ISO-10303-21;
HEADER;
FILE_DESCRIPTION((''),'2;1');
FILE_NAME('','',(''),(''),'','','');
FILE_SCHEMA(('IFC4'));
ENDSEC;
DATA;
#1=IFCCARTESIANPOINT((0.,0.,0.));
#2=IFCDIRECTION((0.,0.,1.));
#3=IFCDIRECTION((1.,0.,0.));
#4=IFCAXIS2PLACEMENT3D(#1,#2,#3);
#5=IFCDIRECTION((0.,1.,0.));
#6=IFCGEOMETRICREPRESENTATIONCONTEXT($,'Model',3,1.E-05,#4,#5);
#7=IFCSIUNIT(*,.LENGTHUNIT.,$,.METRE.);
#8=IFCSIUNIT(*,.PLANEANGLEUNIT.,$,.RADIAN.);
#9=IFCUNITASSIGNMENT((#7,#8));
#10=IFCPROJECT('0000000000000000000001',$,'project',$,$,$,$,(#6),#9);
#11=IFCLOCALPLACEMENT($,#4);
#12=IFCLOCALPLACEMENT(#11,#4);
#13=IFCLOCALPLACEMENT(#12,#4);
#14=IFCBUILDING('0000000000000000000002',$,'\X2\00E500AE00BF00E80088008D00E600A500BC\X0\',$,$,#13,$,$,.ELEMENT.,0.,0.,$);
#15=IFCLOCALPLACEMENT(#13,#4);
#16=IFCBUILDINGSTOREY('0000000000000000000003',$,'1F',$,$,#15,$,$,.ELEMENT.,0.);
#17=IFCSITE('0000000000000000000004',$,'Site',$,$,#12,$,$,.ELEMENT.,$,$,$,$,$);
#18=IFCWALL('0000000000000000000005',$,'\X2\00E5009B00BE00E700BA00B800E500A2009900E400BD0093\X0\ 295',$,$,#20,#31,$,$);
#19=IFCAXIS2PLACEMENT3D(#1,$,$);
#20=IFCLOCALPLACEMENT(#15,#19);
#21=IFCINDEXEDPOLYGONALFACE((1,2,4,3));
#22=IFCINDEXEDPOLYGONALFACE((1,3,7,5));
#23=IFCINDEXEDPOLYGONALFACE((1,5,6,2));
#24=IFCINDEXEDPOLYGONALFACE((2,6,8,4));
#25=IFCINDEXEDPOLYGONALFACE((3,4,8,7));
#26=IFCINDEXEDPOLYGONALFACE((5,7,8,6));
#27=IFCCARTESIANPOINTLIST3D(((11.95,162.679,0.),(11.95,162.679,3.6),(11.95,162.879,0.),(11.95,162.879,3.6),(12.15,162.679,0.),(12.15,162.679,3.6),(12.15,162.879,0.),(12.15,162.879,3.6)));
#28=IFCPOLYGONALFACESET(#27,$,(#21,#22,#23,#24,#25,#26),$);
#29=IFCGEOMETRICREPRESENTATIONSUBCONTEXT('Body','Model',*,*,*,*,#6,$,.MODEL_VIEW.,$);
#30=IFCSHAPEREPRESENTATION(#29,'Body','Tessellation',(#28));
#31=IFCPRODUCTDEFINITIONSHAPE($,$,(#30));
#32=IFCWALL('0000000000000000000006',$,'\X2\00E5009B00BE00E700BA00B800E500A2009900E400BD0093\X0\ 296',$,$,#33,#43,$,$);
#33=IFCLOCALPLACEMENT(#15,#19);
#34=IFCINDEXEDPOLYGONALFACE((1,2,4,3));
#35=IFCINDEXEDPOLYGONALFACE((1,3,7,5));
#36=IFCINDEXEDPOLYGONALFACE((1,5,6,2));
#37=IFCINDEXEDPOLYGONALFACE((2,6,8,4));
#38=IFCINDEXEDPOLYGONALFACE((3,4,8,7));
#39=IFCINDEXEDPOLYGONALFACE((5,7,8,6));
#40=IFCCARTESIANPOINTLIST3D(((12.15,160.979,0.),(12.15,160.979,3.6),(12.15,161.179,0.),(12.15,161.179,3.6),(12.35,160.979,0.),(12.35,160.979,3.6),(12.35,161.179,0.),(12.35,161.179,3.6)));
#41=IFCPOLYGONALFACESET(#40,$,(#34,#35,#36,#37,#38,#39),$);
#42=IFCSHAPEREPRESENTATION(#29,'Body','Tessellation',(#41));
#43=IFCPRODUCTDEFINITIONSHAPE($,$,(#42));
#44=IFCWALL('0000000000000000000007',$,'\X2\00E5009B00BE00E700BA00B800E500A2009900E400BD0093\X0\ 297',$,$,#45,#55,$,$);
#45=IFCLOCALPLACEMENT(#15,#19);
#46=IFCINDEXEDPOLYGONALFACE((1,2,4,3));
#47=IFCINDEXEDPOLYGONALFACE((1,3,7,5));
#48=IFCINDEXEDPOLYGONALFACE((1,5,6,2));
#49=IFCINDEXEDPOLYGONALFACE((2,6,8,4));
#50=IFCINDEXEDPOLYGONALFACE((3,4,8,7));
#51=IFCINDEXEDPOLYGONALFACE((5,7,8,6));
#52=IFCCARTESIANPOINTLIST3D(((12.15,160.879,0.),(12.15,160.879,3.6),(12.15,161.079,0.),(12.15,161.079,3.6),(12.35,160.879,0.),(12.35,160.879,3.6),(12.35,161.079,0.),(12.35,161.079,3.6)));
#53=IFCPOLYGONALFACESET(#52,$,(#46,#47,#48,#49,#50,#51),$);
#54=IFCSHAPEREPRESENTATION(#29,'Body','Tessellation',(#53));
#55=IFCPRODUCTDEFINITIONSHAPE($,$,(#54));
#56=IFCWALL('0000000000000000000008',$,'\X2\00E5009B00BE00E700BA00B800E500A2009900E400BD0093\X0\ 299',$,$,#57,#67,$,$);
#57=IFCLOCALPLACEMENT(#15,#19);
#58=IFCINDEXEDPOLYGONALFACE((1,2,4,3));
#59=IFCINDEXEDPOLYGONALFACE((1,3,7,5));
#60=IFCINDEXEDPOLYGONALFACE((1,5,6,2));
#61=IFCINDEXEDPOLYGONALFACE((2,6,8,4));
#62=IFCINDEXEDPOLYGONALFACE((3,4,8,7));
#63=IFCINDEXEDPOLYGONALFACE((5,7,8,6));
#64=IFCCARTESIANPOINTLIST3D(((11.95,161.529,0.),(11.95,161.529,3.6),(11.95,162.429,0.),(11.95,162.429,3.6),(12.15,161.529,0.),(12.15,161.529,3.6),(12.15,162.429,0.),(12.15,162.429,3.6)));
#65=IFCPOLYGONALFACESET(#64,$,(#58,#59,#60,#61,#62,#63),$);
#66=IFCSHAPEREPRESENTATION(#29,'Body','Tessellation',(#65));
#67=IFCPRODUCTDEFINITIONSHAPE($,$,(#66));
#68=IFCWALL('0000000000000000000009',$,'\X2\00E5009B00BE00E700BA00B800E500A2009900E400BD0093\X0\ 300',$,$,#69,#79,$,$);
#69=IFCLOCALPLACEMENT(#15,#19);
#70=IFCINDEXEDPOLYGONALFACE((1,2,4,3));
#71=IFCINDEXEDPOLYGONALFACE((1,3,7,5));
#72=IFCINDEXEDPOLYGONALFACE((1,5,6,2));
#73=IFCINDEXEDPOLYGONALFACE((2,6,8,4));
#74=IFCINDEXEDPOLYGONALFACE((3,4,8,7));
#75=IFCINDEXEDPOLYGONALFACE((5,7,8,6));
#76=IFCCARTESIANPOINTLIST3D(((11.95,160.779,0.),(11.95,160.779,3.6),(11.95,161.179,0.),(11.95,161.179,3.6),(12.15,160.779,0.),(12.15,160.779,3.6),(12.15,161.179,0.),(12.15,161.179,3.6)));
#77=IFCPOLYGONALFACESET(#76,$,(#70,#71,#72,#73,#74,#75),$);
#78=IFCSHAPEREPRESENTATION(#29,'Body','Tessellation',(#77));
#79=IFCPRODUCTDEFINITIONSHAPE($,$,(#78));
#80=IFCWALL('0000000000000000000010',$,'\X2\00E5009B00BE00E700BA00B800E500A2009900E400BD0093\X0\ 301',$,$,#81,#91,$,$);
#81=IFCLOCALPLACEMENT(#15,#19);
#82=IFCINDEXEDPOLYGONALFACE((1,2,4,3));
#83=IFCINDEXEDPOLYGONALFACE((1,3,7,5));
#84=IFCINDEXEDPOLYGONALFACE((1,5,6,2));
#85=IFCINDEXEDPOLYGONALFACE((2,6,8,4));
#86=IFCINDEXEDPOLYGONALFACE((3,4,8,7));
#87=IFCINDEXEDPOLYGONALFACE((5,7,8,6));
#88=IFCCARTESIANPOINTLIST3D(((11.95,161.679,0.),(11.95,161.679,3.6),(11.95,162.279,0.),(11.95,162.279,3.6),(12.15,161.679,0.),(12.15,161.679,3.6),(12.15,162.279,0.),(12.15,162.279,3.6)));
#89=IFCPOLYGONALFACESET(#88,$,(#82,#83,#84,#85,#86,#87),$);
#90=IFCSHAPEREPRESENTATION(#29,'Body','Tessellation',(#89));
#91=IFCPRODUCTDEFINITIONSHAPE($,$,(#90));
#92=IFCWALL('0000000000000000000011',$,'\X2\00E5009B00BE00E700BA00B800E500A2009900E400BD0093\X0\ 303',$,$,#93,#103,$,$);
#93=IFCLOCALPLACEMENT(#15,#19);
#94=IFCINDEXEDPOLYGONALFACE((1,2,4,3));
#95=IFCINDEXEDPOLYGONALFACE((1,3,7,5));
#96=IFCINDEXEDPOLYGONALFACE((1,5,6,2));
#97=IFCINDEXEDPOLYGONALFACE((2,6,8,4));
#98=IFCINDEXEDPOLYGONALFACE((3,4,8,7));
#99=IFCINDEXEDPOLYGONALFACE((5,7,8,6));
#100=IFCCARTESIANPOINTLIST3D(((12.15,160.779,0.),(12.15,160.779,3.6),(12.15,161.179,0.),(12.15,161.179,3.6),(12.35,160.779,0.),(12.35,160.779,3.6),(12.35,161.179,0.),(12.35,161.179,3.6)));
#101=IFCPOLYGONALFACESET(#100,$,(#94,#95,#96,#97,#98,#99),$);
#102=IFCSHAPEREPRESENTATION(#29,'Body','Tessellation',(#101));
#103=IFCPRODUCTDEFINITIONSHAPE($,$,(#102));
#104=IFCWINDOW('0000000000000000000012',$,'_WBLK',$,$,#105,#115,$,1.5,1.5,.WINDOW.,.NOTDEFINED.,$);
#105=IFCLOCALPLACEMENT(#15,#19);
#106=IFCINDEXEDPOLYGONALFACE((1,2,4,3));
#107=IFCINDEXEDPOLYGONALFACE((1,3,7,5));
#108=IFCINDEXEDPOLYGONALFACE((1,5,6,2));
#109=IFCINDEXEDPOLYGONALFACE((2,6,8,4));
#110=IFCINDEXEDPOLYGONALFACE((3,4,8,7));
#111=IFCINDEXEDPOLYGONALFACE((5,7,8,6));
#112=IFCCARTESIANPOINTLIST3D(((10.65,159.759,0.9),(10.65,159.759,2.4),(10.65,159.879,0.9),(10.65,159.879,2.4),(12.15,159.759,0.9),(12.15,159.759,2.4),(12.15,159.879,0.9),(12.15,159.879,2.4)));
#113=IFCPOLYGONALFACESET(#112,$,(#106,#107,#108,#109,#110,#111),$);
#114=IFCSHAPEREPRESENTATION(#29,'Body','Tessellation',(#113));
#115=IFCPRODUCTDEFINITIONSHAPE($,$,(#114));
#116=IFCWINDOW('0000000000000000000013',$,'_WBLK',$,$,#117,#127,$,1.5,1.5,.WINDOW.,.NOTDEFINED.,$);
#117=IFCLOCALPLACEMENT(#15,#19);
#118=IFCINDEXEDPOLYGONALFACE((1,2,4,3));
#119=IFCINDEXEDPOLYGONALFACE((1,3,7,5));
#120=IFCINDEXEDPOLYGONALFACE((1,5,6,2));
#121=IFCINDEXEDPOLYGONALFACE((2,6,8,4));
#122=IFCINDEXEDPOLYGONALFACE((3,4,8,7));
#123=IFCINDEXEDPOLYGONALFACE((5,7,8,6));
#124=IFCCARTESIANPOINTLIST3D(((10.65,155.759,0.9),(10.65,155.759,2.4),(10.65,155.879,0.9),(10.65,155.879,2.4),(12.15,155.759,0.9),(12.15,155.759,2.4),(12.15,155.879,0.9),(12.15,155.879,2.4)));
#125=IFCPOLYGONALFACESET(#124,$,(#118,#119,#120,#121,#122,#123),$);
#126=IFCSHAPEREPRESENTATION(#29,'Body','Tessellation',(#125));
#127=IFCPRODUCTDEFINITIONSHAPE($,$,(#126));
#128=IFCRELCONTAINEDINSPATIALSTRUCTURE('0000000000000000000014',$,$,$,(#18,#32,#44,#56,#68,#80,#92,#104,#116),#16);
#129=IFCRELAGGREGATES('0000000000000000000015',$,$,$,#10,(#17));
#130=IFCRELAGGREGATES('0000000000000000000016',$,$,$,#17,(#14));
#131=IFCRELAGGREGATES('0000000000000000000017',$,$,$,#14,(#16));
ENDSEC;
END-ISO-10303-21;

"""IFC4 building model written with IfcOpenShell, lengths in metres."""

from ifc_helpers import new_model, si_unit, direction, frame, frame_2d, origin_with_axes, place, context, subcontext, project, spatial, rectangle, extrude, element, save


model = new_model("IFC4")

# Units and contexts
model_context = context("Model", 3, precision=1e-05, world=origin_with_axes(), true_north=direction((0.0, 1.0, 0.0)))
body_context = subcontext(model_context, "Body", "Model", "MODEL_VIEW")
ifc_project = project(units=[si_unit("LENGTHUNIT", "METRE"), si_unit("PLANEANGLEUNIT", "RADIAN")], contexts=[model_context])

# Site, building, storey
placement = place(None, origin_with_axes())
site_placement = place(placement, origin_with_axes())
site = spatial("IfcSite", under=ifc_project, at=site_placement, Name="Site", CompositionType="ELEMENT")
building_placement = place(site_placement, origin_with_axes())
building = spatial("IfcBuilding", under=site, at=building_placement, Name="å®¿è\u0088\u008dæ¥¼", CompositionType="ELEMENT", ElevationOfRefHeight=0.0, ElevationOfTerrain=0.0)
storey_placement = place(building_placement, origin_with_axes())
storey = spatial("IfcBuildingStorey", under=building, at=storey_placement, Name="1F", CompositionType="ELEMENT", Elevation=0.0)

# Walls
for number, where, z_axis, x_axis, name in (
    (1, (12.05, 162.779, 0.0), (0.0, 0.0, 1.0), (1.0, 0.0, 0.0), "å\u009b¾çº¸å¢\u0099ä½\u0093 295"),
    (2, (12.25, 161.079, 0.0), (0.0, 0.0, 1.0), (-1.0, 0.0, 0.0), "å\u009b¾çº¸å¢\u0099ä½\u0093 296"),
    (3, (12.25, 160.979, 0.0), (0.0, 0.0, 1.0), (-1.0, 0.0, 0.0), "å\u009b¾çº¸å¢\u0099ä½\u0093 297"),
):
    element("IfcWall", number, at=place(storey_placement, frame(where, z_axis=z_axis, x_axis=x_axis)), inside=storey, Name=name, context=body_context, shape_type="SweptSolid", body=[
        extrude(rectangle(XDim=0.2, YDim=0.2, at=frame_2d((0.0, 0.0), x_axis=(1.0, 0.0, 0.0))), frame((0.0, 0.0, 0.0), z_axis=(0.0, 0.0, 1.0)), (0.0, 0.0, 1.0), 3.6),
    ])
wall_1_placement = place(storey_placement, frame((12.05, 161.979, 0.0), z_axis=(0.0, 0.0, 1.0), x_axis=(0.0, 1.0, 0.0)))
element("IfcWall", 4, at=wall_1_placement, inside=storey, Name="å\u009b¾çº¸å¢\u0099ä½\u0093 299", context=body_context, shape_type="SweptSolid", body=[
    extrude(rectangle(XDim=0.9, YDim=0.2, at=frame_2d((0.0, 0.0), x_axis=(1.0, 0.0, 0.0))), frame((0.0, 0.0, 0.0), z_axis=(0.0, 0.0, 1.0)), (0.0, 0.0, 1.0), 3.6),
])
wall_2_placement = place(storey_placement, frame((12.05, 160.979, 0.0), z_axis=(0.0, 0.0, 1.0), x_axis=(0.0, 1.0, 0.0)))
element("IfcWall", 5, at=wall_2_placement, inside=storey, Name="å\u009b¾çº¸å¢\u0099ä½\u0093 300", context=body_context, shape_type="SweptSolid", body=[
    extrude(rectangle(XDim=0.4, YDim=0.2, at=frame_2d((0.0, 0.0), x_axis=(1.0, 0.0, 0.0))), frame((0.0, 0.0, 0.0), z_axis=(0.0, 0.0, 1.0)), (0.0, 0.0, 1.0), 3.6),
])
wall_3_placement = place(storey_placement, frame((12.05, 161.979, 0.0), z_axis=(0.0, 0.0, 1.0), x_axis=(0.0, -1.0, 0.0)))
element("IfcWall", 6, at=wall_3_placement, inside=storey, Name="å\u009b¾çº¸å¢\u0099ä½\u0093 301", context=body_context, shape_type="SweptSolid", body=[
    extrude(rectangle(XDim=0.6, YDim=0.2, at=frame_2d((0.0, 0.0), x_axis=(1.0, 0.0, 0.0))), frame((0.0, 0.0, 0.0), z_axis=(0.0, 0.0, 1.0)), (0.0, 0.0, 1.0), 3.6),
])
wall_4_placement = place(storey_placement, frame((12.25, 160.979, 0.0), z_axis=(0.0, 0.0, 1.0), x_axis=(0.0, 1.0, 0.0)))
element("IfcWall", 7, at=wall_4_placement, inside=storey, Name="å\u009b¾çº¸å¢\u0099ä½\u0093 303", context=body_context, shape_type="SweptSolid", body=[
    extrude(rectangle(XDim=0.4, YDim=0.2, at=frame_2d((0.0, 0.0), x_axis=(1.0, 0.0, 0.0))), frame((0.0, 0.0, 0.0), z_axis=(0.0, 0.0, 1.0)), (0.0, 0.0, 1.0), 3.6),
])

# Windows
for number, where, z_axis, x_axis, name in (
    (8, (11.4, 159.819, 0.9), (0.0, 0.0, 1.0), (1.0, 0.0, 0.0), "_WBLK"),
    (9, (11.4, 155.819, 0.9), (0.0, 0.0, 1.0), (1.0, 0.0, 0.0), "_WBLK"),
):
    element("IfcWindow", number, at=place(storey_placement, frame(where, z_axis=z_axis, x_axis=x_axis)), inside=storey, Name=name, OverallHeight=1.5, OverallWidth=1.5, PartitioningType="NOTDEFINED", PredefinedType="WINDOW", context=body_context, shape_type="SweptSolid", body=[
        extrude(rectangle(XDim=1.5, YDim=0.12, at=frame_2d((0.0, 0.0), x_axis=(1.0, 0.0, 0.0))), frame((0.0, 0.0, 0.0), z_axis=(0.0, 0.0, 1.0)), (0.0, 0.0, 1.0), 1.5),
    ])

save(model, "model.ifc")
